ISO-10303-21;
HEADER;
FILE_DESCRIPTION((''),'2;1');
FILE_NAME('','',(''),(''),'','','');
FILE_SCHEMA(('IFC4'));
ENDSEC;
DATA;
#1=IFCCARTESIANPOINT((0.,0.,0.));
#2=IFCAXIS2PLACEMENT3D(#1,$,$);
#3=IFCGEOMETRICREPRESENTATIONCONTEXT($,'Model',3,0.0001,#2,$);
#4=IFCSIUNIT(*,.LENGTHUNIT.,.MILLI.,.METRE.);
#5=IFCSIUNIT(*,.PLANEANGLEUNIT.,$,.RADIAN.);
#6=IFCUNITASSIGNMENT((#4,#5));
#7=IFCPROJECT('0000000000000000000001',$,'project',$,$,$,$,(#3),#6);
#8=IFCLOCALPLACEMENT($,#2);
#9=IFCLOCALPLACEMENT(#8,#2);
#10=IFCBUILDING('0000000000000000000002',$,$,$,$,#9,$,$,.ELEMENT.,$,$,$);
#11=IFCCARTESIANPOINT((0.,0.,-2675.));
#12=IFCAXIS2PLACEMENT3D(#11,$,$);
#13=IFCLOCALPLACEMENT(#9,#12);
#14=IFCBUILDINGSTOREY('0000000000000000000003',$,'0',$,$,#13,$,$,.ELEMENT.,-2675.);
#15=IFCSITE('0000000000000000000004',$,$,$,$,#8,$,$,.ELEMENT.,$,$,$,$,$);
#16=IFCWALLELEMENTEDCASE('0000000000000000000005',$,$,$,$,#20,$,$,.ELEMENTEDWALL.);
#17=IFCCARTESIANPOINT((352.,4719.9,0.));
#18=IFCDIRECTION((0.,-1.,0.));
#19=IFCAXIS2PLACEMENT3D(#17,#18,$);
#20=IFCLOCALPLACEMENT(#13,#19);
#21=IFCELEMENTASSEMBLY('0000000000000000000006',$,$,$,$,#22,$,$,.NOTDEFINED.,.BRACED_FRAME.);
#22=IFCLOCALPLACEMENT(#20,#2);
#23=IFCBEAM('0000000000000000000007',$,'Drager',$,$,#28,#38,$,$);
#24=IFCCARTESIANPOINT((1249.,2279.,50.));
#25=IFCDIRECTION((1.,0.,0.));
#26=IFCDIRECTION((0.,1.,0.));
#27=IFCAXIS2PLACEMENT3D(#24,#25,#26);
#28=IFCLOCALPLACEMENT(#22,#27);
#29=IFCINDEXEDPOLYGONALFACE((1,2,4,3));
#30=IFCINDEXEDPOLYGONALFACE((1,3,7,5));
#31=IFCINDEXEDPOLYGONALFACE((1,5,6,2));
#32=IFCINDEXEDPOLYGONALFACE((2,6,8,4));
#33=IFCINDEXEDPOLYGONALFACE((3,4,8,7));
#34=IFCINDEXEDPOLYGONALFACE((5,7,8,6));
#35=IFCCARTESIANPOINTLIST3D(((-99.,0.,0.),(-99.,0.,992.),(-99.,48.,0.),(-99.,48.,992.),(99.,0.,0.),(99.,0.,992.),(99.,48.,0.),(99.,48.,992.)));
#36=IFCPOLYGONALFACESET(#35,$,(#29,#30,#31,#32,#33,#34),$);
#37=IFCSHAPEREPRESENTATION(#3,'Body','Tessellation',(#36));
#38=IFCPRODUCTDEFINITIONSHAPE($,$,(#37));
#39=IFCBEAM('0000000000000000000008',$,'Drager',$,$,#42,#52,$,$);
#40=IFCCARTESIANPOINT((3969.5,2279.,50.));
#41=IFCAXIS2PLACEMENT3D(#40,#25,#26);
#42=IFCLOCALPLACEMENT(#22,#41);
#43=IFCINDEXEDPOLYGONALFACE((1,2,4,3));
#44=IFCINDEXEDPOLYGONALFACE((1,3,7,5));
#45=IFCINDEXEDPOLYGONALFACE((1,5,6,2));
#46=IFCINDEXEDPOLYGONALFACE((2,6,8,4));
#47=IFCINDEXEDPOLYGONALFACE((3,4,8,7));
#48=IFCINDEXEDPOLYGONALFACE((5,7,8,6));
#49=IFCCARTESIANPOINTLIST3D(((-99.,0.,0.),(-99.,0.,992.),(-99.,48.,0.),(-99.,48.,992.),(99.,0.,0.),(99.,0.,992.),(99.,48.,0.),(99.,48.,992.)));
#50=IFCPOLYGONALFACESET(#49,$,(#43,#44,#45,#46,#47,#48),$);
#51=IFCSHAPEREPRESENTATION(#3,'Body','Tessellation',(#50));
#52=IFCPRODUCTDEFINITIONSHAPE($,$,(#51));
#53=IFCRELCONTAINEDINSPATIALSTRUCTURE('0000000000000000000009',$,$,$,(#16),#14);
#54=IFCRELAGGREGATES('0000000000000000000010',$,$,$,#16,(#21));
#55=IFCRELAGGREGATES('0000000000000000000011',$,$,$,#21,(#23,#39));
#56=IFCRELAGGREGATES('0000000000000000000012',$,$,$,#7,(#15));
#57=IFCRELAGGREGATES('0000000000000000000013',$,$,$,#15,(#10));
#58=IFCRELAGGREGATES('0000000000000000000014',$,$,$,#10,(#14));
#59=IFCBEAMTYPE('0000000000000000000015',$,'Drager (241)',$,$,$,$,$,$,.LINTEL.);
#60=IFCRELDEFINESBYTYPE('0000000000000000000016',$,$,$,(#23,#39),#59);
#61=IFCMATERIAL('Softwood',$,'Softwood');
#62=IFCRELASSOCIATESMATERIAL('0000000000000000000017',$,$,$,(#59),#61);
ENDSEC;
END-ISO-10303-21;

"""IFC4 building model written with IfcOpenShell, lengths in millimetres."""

from ifc_helpers import new_model, si_unit, frame, origin, place, context, project, spatial, rectangle, extrude, material, material_profile, profile_set, type_object, element, aggregate, save


model = new_model("IFC4")

# Units and contexts
model_context = context("Model", 3, precision=0.0001, world=origin())
ifc_project = project(units=[si_unit("LENGTHUNIT", "METRE", prefix="MILLI"), si_unit("PLANEANGLEUNIT", "RADIAN")], contexts=[model_context])

# Site, building, storey
site_placement = place(None, origin())
site = spatial("IfcSite", under=ifc_project, at=site_placement, CompositionType="ELEMENT")
building_placement = place(site_placement, origin())
building = spatial("IfcBuilding", under=site, at=building_placement, CompositionType="ELEMENT")
storey_placement = place(building_placement, frame((0.0, 0.0, -2675.0)))
storey = spatial("IfcBuildingStorey", under=building, at=storey_placement, Name="0", CompositionType="ELEMENT", Elevation=-2675.0)

# Wall, element assembly
wall_1_placement = place(storey_placement, frame((352.0, 4719.9, 0.0), z_axis=(0.0, -1.0, 0.0)))
wall_1 = element("IfcWallElementedCase", 1, at=wall_1_placement, inside=storey, PredefinedType="ELEMENTEDWALL")
assembly_1_placement = place(wall_1_placement, origin())
assembly_1 = element("IfcElementAssembly", 2, at=assembly_1_placement, AssemblyPlace="NOTDEFINED", PredefinedType="BRACED_FRAME")
aggregate(wall_1, [assembly_1])

# Beams
ifc_material_1 = material(Name="Softwood", Category="Softwood")
ifc_material_profile_1 = material_profile(ifc_material_1, rectangle(XDim=198.0, YDim=48.0), Name="Drager (241)")
ifc_profile_set_1 = profile_set([ifc_material_profile_1])
beam_type_1 = type_object("IfcBeamType", Name="Drager (241)", PredefinedType="LINTEL", material=ifc_profile_set_1)
beam_1_placement = place(assembly_1_placement, frame((1249.0, 2279.0, 50.0), z_axis=(1.0, 0.0, 0.0), x_axis=(0.0, 1.0, 0.0)))
beam_1 = element("IfcBeam", 3, at=beam_1_placement, type_object=beam_type_1, Name="Drager", context=model_context, shape_type="SweptSolid", body=[
    extrude(rectangle(XDim=198.0, YDim=48.0), frame((0.0, 24.0, 0.0)), (0.0, 0.0, 1.0), 992.0),
])
beam_2_placement = place(assembly_1_placement, frame((3969.5, 2279.0, 50.0), z_axis=(1.0, 0.0, 0.0), x_axis=(0.0, 1.0, 0.0)))
beam_2 = element("IfcBeam", 4, at=beam_2_placement, type_object=beam_type_1, Name="Drager", context=model_context, shape_type="SweptSolid", body=[
    extrude(rectangle(XDim=198.0, YDim=48.0), frame((0.0, 24.0, 0.0)), (0.0, 0.0, 1.0), 992.0),
])

aggregate(assembly_1, [beam_1, beam_2])

save(model, "model.ifc")
